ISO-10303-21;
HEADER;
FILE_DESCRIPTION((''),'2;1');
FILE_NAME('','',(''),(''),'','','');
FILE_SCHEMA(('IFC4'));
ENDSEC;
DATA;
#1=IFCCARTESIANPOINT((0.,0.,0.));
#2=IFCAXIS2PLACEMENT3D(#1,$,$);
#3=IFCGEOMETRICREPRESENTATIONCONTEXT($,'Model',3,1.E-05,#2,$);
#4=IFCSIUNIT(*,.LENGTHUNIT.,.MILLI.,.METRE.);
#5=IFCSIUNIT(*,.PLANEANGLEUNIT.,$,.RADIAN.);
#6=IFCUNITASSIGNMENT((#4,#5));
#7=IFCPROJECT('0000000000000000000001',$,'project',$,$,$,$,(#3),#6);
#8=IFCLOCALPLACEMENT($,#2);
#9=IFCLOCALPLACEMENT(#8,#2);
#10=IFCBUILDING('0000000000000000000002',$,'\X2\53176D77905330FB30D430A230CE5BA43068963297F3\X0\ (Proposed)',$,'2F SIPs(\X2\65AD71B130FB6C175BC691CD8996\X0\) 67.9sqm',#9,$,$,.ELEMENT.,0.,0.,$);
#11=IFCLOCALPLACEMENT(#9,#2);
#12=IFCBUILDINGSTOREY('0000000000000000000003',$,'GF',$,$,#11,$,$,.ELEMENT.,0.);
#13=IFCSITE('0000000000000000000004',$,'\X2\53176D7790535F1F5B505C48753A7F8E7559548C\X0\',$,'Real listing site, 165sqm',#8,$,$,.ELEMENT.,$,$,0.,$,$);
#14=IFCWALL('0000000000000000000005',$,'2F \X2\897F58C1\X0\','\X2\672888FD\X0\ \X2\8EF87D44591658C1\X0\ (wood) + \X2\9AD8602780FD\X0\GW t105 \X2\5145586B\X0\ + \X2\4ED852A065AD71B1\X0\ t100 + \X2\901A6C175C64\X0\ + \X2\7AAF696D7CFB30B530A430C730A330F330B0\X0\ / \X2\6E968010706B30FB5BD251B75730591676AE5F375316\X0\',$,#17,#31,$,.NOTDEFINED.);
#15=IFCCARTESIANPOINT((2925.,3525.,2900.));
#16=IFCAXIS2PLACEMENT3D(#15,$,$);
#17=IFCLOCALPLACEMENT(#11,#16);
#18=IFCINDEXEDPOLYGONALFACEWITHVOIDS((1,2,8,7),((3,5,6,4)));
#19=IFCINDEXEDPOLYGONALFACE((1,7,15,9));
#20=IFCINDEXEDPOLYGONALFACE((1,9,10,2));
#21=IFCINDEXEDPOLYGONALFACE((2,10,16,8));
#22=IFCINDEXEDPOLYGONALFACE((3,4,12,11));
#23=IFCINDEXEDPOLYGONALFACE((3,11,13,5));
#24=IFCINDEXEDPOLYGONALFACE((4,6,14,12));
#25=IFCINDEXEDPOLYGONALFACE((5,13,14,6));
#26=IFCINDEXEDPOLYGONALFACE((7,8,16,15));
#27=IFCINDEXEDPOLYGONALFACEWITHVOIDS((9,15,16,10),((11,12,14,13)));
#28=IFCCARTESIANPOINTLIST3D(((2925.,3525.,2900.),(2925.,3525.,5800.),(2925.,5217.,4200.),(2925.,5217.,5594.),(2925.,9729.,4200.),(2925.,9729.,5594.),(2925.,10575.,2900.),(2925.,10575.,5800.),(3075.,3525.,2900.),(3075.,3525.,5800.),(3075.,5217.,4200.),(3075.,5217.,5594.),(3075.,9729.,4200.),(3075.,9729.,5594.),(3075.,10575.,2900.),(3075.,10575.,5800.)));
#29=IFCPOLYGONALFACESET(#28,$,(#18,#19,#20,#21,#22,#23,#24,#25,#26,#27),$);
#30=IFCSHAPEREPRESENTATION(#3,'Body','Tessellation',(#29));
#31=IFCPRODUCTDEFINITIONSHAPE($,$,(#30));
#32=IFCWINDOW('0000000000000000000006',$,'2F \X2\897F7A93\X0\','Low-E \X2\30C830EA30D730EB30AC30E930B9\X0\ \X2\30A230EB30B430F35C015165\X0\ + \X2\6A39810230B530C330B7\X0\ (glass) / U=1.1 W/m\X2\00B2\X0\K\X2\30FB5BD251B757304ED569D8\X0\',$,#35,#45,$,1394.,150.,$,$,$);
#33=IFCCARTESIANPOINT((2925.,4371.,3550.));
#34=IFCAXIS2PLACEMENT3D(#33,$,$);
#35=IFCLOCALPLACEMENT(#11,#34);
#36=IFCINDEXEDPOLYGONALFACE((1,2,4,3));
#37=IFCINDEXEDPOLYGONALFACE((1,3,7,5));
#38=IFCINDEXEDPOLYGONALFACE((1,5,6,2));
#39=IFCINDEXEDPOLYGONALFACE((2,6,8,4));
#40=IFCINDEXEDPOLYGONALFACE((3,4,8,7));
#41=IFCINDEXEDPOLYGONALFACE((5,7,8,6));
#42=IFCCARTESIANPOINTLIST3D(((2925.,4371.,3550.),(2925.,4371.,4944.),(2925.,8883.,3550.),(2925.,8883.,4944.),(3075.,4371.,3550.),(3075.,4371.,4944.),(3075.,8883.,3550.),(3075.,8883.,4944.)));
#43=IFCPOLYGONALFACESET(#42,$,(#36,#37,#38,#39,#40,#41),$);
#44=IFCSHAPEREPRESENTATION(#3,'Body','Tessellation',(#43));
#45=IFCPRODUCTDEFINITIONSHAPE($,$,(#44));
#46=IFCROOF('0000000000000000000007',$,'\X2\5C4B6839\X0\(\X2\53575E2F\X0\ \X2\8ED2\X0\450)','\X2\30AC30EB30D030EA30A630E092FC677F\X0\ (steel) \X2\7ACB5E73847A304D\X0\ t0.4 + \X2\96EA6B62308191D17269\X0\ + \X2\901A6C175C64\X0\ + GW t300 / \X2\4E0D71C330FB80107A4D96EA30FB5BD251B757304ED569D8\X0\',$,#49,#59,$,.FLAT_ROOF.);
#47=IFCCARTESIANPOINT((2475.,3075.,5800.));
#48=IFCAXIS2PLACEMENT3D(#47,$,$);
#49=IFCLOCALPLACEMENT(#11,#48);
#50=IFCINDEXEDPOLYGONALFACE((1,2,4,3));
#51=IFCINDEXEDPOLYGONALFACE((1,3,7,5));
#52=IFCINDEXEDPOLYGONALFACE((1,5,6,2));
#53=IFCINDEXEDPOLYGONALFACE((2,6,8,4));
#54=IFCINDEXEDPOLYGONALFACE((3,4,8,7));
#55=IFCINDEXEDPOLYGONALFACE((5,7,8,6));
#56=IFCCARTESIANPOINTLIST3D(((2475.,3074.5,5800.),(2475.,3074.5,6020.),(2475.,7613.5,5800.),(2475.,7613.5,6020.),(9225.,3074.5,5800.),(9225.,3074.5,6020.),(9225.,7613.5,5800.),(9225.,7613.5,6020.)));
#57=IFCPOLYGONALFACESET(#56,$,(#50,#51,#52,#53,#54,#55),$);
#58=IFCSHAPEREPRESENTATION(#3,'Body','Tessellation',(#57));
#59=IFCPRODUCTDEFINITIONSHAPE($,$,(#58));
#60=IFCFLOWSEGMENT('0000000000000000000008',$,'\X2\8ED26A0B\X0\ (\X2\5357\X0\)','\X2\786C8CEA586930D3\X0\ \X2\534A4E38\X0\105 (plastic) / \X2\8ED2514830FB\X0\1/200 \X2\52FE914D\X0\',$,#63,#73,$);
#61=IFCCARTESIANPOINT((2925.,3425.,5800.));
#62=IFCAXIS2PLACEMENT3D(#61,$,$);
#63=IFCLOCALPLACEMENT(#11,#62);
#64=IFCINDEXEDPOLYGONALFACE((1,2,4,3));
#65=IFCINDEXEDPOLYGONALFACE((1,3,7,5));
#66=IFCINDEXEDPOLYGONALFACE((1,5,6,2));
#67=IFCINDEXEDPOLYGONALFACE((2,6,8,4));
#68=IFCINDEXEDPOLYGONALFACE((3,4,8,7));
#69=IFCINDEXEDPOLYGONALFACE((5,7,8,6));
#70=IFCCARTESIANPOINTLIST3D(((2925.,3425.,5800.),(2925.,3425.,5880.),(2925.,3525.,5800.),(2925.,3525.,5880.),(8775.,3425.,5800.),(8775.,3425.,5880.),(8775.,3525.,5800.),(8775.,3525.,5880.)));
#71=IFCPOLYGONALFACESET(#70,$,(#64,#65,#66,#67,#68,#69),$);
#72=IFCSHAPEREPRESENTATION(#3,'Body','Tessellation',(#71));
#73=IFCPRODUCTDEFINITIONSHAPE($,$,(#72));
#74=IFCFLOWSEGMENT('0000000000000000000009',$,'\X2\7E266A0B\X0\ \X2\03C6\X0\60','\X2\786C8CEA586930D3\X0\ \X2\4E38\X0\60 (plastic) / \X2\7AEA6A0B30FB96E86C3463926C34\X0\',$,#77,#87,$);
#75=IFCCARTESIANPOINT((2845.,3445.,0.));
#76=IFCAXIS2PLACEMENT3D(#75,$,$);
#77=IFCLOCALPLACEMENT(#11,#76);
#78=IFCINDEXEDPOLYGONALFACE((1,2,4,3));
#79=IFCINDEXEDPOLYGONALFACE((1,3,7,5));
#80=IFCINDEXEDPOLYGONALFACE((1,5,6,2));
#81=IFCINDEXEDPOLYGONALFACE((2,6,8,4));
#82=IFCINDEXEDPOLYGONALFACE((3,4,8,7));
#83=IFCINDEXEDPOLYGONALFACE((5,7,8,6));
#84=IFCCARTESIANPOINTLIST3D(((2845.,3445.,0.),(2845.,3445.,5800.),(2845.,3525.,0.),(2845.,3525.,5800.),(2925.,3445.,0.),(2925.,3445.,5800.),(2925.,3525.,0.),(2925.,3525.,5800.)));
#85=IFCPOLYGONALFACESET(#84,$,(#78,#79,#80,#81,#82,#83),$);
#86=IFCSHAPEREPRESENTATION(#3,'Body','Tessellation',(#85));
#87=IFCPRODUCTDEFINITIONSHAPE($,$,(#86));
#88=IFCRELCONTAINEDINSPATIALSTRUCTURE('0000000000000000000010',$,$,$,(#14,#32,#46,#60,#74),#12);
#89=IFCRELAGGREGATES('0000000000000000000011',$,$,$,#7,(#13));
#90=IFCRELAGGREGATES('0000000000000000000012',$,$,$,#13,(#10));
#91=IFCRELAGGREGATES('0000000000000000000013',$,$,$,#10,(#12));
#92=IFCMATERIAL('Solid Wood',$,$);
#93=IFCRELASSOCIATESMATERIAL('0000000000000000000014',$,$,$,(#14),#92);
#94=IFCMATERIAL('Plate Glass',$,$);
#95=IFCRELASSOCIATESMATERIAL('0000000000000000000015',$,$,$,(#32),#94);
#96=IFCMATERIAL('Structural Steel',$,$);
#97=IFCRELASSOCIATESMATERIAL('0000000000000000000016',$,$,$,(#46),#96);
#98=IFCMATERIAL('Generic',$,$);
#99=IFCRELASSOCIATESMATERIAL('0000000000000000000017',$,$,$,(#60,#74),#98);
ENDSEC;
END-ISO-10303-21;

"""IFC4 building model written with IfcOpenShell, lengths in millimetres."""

from ifc_helpers import new_model, si_unit, frame, frame_2d, origin, place, context, project, spatial, rectangle, extrude, material, element, fill, save


model = new_model("IFC4")

# Units and contexts
model_context = context("Model", 3, precision=1e-05, world=origin())
ifc_project = project(units=[si_unit("LENGTHUNIT", "METRE", prefix="MILLI"), si_unit("PLANEANGLEUNIT", "RADIAN")], contexts=[model_context])

# Site, building, storey
site_placement = place(None, origin())
site = spatial("IfcSite", under=ifc_project, at=site_placement, Name="北海道弟子屈町美留和", ObjectType="Real listing site, 165sqm", CompositionType="ELEMENT", RefElevation=0.0)
building_placement = place(site_placement, origin())
building = spatial("IfcBuilding", under=site, at=building_placement, Name="北海道・ピアノ室と防音 (Proposed)", ObjectType="2F SIPs(断熱・気密重視) 67.9sqm", CompositionType="ELEMENT", ElevationOfRefHeight=0.0, ElevationOfTerrain=0.0)
storey_placement = place(building_placement, origin())
storey = spatial("IfcBuildingStorey", under=building, at=storey_placement, Name="GF", CompositionType="ELEMENT", Elevation=0.0)

# Shared definitions
ifc_material_1 = material(Name="Solid Wood")

# Shared definitions
ifc_material_2 = material(Name="Plate Glass")

# Wall, opening, window
wall_1_placement = place(storey_placement, frame((2925.0, 3525.0, 2900.0)))
wall_1 = element("IfcWall", 1, at=wall_1_placement, inside=storey, material=ifc_material_1, Name="2F 西壁", Description="木製 軸組外壁 (wood) + 高性能GW t105 充填 + 付加断熱 t100 + 通気層 + 窯業系サイディング / 準耐火・寒冷地外皮強化", PredefinedType="NOTDEFINED", context=model_context, shape_type="SweptSolid", body=[
    extrude(rectangle(XDim=150.0, YDim=7050.0, at=frame_2d((75.0, 3525.0))), frame((2925.0, 3525.0, 2900.0)), (0.0, 0.0, 1.0), 2900.0),
])
opening_1_placement = place(storey_placement, frame((2925.0, 4371.0, 3550.0)))
opening_1 = element("IfcOpeningElement", 2, at=opening_1_placement, cuts=wall_1, PredefinedType="NOTDEFINED", context=model_context, shape_type="SweptSolid", body=[
    extrude(rectangle(XDim=150.0, YDim=4512.0, at=frame_2d((75.0, 2256.0))), frame((2925.0, 4371.0, 3550.0)), (0.0, 0.0, 1.0), 1394.0),
])
window_1_placement = place(storey_placement, frame((2925.0, 4371.0, 3550.0)))
window_1 = element("IfcWindow", 3, at=window_1_placement, inside=storey, material=ifc_material_2, Name="2F 西窓", Description="Low-E トリプルガラス アルゴン封入 + 樹脂サッシ (glass) / U=1.1 W/m²K・寒冷地仕様", OverallHeight=1394.0, OverallWidth=150.0, context=model_context, shape_type="SweptSolid", body=[
    extrude(rectangle(XDim=150.0, YDim=4512.0, at=frame_2d((75.0, 2256.0))), frame((2925.0, 4371.0, 3550.0)), (0.0, 0.0, 1.0), 1394.0),
])
fill(opening_1, window_1)

# Roof
ifc_material_3 = material(Name="Structural Steel")
for number, where, name in (
    (4, (2475.0, 3075.0, 5800.0), "屋根(南帯 軒450)"),
):
    element("IfcRoof", number, at=place(storey_placement, frame(where)), inside=storey, material=ifc_material_3, Name=name, Description="ガルバリウム鋼板 (steel) 立平葺き t0.4 + 雪止め金物 + 通気層 + GW t300 / 不燃・耐積雪・寒冷地仕様", PredefinedType="FLAT_ROOF", context=model_context, shape_type="SweptSolid", body=[
        extrude(rectangle(XDim=6750.0, YDim=4539.0, at=frame_2d((3375.0, 2269.0))), frame((2475.0, 3075.0, 5800.0)), (0.0, 0.0, 1.0), 220.0),
    ])

# Flow segments
ifc_material_4 = material(Name="Generic")
flow_segment_1_placement = place(storey_placement, frame((2925.0, 3425.0, 5800.0)))
element("IfcFlowSegment", 5, at=flow_segment_1_placement, inside=storey, material=ifc_material_4, Name="軒樋 (南)", Description="硬質塩ビ 半丸105 (plastic) / 軒先・1/200 勾配", context=model_context, shape_type="SweptSolid", body=[
    extrude(rectangle(XDim=5850.0, YDim=100.0, at=frame_2d((2925.0, 50.0))), frame((2925.0, 3425.0, 5800.0)), (0.0, 0.0, 1.0), 80.0),
])
flow_segment_2_placement = place(storey_placement, frame((2845.0, 3445.0, 0.0)))
element("IfcFlowSegment", 6, at=flow_segment_2_placement, inside=storey, material=ifc_material_4, Name="縦樋 φ60", Description="硬質塩ビ 丸60 (plastic) / 竪樋・雨水排水", context=model_context, shape_type="SweptSolid", body=[
    extrude(rectangle(XDim=80.0, YDim=80.0, at=frame_2d((40.0, 40.0))), frame((2845.0, 3445.0, 0.0)), (0.0, 0.0, 1.0), 5800.0),
])

save(model, "model.ifc")
